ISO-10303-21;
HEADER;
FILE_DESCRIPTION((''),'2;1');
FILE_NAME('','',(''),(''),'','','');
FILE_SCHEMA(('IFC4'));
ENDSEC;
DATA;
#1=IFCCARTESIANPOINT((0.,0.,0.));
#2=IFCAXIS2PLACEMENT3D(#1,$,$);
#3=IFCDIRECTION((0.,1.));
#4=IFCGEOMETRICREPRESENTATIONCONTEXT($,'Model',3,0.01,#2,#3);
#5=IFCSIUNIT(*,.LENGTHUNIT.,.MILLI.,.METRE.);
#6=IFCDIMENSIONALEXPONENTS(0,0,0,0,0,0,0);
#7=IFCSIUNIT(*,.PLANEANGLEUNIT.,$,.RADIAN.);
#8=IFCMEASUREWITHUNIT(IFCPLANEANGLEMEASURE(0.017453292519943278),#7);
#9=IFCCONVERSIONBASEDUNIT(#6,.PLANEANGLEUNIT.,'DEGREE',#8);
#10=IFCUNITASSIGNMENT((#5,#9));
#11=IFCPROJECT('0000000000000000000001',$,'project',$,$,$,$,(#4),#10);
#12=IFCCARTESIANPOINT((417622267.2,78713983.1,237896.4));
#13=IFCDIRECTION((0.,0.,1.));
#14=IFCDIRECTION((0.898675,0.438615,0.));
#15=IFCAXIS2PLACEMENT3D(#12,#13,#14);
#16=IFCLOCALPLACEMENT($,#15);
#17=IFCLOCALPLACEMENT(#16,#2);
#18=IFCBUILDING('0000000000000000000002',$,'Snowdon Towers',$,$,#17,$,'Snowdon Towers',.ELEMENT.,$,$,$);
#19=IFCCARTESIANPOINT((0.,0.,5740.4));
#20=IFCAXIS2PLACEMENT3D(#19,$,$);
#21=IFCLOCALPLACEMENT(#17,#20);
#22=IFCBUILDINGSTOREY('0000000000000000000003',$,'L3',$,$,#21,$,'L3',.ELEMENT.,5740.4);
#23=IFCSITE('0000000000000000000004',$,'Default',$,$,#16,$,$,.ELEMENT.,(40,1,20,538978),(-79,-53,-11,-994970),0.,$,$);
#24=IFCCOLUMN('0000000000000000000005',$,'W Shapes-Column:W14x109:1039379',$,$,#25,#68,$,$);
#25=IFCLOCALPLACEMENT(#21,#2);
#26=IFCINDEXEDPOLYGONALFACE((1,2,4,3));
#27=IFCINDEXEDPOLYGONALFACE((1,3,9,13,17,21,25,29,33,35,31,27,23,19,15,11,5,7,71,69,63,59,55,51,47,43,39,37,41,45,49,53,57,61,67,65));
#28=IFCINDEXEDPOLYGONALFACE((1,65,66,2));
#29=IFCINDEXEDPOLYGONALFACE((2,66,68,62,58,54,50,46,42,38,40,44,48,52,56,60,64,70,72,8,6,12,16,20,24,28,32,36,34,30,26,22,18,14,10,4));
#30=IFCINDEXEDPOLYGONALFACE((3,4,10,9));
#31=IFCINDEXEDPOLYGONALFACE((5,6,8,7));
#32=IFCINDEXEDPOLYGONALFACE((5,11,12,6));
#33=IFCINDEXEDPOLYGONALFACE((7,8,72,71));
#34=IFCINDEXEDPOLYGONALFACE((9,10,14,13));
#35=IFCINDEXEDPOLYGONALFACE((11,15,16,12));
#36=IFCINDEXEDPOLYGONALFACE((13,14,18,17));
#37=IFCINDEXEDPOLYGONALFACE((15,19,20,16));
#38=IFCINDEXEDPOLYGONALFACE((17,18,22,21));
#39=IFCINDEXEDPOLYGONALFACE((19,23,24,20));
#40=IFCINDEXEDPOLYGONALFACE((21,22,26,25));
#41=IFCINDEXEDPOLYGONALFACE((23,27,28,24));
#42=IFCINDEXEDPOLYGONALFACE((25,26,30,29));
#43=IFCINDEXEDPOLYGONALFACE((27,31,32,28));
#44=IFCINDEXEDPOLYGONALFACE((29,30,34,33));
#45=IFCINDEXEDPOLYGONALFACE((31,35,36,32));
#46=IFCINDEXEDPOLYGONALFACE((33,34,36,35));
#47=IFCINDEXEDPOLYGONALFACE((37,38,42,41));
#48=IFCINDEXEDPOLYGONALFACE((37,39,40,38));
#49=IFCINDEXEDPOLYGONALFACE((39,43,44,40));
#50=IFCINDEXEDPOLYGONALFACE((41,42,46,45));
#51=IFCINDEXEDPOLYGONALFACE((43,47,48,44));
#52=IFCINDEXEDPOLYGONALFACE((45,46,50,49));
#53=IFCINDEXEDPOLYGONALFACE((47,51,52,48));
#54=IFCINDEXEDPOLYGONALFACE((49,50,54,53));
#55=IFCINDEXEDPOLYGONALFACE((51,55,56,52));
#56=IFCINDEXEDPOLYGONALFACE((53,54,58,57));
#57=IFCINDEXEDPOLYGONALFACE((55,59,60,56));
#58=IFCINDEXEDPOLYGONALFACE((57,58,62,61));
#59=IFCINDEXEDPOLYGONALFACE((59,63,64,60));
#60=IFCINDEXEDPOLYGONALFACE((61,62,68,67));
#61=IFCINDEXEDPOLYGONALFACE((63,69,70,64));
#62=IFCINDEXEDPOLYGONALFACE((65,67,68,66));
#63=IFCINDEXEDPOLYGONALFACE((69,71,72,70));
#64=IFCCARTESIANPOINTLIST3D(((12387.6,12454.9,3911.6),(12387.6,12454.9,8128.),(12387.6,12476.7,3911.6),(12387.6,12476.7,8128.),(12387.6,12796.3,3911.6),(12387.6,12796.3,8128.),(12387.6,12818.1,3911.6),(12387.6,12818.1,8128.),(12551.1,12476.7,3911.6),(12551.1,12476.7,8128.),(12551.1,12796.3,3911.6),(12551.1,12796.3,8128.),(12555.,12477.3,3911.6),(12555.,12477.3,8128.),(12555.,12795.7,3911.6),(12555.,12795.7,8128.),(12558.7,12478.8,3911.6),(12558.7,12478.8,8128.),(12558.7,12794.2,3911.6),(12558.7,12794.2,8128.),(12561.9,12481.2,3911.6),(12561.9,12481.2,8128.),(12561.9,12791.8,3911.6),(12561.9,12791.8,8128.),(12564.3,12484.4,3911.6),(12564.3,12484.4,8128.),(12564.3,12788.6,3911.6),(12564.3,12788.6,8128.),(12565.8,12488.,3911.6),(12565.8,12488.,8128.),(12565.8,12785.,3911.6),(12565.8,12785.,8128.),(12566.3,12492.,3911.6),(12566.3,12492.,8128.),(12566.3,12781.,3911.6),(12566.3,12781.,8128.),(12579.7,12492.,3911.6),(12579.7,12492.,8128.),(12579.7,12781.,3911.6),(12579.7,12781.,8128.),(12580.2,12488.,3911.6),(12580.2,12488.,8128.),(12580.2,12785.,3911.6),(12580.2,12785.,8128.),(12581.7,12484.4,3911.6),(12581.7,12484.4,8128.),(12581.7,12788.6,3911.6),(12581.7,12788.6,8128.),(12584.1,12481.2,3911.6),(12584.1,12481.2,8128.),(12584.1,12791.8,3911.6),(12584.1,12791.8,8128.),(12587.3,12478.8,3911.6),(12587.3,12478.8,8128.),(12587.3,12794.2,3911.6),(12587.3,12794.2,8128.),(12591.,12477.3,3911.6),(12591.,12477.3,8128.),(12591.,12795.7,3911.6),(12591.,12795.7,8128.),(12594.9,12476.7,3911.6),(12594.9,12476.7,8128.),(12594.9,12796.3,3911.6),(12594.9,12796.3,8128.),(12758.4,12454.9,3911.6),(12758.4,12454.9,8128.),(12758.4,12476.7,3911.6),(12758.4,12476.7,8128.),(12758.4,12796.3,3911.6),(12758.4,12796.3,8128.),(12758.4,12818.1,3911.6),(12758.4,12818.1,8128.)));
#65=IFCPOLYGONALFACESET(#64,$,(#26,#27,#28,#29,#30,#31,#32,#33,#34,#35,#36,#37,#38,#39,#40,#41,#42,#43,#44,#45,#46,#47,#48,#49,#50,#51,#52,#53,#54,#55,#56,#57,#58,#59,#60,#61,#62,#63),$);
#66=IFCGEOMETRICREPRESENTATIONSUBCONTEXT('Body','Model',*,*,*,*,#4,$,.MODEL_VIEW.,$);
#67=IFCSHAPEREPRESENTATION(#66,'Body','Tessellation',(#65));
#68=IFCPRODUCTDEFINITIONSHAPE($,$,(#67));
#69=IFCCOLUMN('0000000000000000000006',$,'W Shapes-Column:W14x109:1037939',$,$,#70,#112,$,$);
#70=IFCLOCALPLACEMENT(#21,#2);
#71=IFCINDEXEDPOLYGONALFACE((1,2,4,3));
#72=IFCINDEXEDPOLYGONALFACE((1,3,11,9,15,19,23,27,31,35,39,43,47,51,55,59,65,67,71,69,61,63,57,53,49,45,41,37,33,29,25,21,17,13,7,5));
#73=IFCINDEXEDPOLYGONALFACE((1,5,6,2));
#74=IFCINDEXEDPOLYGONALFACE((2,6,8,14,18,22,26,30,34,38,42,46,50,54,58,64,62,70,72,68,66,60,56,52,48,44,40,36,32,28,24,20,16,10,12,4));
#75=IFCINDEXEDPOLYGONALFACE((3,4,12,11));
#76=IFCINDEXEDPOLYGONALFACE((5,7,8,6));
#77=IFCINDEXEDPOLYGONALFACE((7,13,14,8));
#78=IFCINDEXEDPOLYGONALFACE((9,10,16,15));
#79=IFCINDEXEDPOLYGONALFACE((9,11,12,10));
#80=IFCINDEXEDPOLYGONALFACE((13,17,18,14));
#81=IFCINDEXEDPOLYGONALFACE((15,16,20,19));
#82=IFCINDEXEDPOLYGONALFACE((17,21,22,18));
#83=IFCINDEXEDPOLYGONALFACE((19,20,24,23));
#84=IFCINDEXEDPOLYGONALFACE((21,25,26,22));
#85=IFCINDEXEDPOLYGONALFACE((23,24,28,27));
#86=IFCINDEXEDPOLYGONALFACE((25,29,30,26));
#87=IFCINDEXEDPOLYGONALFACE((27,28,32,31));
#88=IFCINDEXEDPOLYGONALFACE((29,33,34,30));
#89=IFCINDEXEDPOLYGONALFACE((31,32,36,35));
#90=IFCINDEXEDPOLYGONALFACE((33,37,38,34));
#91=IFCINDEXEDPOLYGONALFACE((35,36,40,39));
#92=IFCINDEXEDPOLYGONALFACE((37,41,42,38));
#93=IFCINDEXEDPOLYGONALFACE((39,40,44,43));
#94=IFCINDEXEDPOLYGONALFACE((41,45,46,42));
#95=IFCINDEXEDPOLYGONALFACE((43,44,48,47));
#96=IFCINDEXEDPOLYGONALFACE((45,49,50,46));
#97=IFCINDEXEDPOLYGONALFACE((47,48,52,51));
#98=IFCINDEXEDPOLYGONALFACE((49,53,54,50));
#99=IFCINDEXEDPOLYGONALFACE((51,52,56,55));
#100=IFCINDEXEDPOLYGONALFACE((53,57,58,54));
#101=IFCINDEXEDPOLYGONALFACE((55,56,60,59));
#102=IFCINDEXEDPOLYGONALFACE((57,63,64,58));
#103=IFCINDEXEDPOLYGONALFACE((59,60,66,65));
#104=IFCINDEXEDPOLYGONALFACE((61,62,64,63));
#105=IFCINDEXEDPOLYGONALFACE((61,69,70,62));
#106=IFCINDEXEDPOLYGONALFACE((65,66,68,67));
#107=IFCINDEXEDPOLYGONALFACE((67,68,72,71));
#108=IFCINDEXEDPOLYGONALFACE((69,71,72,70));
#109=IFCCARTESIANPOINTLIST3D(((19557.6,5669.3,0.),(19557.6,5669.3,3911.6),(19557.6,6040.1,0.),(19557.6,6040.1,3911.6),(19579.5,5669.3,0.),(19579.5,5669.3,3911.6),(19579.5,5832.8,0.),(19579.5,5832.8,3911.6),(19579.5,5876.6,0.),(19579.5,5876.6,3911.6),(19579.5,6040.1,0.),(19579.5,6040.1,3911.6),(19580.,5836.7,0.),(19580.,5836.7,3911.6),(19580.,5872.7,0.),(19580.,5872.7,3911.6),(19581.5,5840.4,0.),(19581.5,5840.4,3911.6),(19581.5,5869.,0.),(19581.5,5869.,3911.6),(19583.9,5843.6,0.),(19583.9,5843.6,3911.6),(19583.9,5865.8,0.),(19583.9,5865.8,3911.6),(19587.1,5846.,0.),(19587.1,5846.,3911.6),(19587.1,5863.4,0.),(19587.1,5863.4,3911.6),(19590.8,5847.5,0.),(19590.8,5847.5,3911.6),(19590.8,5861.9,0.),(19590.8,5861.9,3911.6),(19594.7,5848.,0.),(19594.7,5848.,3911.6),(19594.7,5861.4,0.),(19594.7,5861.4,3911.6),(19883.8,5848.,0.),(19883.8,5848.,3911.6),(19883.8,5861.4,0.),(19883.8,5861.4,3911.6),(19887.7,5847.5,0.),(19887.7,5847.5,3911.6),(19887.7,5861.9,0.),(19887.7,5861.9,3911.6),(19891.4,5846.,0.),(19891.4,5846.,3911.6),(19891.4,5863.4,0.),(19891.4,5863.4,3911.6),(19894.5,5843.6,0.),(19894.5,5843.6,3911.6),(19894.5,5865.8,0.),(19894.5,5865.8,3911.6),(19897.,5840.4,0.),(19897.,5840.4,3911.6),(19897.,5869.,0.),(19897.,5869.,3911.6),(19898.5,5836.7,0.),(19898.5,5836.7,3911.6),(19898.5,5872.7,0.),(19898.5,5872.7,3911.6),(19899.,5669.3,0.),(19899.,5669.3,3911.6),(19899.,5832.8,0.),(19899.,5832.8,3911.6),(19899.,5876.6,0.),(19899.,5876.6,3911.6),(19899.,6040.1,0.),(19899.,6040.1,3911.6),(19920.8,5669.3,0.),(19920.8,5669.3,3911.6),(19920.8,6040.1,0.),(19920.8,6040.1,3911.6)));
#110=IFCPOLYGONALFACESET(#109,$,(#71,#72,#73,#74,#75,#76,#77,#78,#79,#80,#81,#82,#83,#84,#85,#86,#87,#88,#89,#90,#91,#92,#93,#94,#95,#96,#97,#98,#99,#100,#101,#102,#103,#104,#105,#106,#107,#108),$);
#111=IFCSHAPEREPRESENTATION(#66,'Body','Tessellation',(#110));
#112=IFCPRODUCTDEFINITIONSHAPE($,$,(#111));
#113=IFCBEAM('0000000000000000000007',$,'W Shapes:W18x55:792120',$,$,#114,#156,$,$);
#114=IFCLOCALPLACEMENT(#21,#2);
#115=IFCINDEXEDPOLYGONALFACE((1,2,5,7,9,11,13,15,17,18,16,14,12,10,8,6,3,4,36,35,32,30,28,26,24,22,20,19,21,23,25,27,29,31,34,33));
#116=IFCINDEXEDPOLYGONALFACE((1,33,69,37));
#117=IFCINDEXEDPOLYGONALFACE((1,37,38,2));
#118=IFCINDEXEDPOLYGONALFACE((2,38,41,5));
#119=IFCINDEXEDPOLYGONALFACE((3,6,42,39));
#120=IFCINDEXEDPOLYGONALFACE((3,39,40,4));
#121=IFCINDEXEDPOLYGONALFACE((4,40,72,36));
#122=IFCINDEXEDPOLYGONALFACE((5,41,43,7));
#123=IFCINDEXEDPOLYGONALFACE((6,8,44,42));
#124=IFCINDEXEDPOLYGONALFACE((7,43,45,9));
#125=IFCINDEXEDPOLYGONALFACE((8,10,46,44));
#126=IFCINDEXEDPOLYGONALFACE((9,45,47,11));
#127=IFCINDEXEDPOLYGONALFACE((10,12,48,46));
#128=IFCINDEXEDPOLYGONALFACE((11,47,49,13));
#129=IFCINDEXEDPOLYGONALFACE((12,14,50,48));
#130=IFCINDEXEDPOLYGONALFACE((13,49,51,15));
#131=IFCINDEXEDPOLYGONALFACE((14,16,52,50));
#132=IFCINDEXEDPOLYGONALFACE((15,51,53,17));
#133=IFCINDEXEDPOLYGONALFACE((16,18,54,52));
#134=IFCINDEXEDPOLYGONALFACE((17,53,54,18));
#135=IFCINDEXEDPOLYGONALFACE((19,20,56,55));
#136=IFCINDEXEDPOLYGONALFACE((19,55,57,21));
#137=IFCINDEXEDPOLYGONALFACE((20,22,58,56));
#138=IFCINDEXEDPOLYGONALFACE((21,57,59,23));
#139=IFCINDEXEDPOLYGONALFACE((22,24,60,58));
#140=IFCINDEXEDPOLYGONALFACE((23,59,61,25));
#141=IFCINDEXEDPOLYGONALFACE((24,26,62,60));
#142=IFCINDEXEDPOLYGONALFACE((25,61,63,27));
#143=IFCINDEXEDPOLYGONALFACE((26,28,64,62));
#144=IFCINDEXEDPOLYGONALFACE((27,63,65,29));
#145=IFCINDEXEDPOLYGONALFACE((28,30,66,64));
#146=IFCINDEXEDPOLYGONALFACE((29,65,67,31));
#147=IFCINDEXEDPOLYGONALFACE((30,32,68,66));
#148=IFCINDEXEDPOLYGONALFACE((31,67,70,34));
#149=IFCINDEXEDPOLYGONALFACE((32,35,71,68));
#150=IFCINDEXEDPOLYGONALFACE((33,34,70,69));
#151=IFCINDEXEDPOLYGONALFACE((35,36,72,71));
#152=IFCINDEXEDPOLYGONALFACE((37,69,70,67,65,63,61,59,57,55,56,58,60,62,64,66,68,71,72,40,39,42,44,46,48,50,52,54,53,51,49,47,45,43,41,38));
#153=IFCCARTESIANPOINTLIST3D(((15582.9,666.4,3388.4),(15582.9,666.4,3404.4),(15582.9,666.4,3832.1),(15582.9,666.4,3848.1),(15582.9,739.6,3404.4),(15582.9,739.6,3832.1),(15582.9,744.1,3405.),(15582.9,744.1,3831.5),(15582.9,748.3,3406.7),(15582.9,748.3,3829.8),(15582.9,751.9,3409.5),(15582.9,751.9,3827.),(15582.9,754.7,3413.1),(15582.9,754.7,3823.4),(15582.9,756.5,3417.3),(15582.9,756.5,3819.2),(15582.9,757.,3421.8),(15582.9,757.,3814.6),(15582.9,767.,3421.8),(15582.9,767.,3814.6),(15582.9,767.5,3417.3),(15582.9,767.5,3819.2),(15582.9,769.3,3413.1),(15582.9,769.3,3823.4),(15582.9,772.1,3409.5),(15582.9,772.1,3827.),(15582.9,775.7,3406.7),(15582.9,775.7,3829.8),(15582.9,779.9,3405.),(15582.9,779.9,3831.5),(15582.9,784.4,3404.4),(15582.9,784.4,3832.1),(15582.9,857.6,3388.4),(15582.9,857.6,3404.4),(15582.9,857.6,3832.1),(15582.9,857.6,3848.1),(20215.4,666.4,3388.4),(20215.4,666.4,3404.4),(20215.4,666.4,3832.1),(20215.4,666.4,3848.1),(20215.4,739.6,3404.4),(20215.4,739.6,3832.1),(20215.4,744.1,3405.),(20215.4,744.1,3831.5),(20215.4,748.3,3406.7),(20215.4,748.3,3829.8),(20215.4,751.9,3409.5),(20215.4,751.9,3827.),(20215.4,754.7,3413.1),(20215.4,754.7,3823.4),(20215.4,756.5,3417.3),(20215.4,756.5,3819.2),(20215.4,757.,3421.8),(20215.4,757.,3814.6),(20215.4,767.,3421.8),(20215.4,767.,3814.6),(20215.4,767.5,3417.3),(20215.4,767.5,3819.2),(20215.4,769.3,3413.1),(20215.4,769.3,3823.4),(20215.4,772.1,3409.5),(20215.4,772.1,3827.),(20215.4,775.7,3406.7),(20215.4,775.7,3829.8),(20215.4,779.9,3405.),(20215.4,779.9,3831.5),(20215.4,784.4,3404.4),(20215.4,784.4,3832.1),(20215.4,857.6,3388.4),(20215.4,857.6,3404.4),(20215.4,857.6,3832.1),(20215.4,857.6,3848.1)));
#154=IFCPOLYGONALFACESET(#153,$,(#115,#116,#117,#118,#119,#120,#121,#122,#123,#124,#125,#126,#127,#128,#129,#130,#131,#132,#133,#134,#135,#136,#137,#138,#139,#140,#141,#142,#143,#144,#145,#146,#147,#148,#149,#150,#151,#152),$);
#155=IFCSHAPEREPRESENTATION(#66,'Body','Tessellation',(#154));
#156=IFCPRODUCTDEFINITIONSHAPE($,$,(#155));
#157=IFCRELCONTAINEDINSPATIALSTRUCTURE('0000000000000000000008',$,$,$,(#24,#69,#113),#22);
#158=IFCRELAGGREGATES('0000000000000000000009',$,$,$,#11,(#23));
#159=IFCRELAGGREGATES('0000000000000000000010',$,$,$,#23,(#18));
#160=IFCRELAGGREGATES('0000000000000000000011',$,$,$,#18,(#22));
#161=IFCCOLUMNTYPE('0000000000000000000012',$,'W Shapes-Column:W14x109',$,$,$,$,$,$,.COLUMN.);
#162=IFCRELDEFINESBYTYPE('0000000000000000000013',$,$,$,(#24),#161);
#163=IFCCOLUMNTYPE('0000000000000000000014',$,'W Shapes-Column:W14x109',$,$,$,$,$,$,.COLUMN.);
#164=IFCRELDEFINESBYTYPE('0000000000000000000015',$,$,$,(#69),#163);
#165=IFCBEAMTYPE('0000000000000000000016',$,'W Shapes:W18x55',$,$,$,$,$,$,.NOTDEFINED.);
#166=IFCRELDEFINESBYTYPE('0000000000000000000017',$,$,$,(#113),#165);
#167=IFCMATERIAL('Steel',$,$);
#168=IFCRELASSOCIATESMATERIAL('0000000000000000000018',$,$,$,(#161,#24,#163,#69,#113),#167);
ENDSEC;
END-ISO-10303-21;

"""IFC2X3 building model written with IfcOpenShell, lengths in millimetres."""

from ifc_helpers import new_model, entity, si_unit, converted_unit, direction, frame, frame_2d, origin, place, context, subcontext, project, spatial, i_section, extrude, source, transform, mapped, material, type_object, type_shapes, element, save


model = new_model("IFC2X3")

# Units and contexts
model_context = context("Model", 3, precision=0.01, world=origin(), true_north=direction((0.0, 1.0)))
body_context = subcontext(model_context, "Body", "Model", "MODEL_VIEW")
ifc_project = project(units=[si_unit("LENGTHUNIT", "METRE", prefix="MILLI"), converted_unit("PLANEANGLEUNIT", "DEGREE", entity("IfcPlaneAngleMeasure", 0.017453292519943278), si_unit("PLANEANGLEUNIT", "RADIAN"), dimensions=[0, 0, 0, 0, 0, 0, 0])], contexts=[model_context])

# Site, building, storey
site_placement = place(None, frame((417622267.2, 78713983.1, 237896.4), z_axis=(0.0, 0.0, 1.0), x_axis=(0.898675, 0.438615, 0.0)))
site = spatial("IfcSite", under=ifc_project, at=site_placement, Name="Default", CompositionType="ELEMENT", RefLatitude=(40, 1, 20, 538978), RefLongitude=(-79, -53, -11, -994970), RefElevation=0.0)
building_placement = place(site_placement, origin())
building = spatial("IfcBuilding", under=site, at=building_placement, Name="Snowdon Towers", LongName="Snowdon Towers", CompositionType="ELEMENT")
storey_placement = place(building_placement, frame((0.0, 0.0, 5740.4)))
storey = spatial("IfcBuildingStorey", under=building, at=storey_placement, Name="L3", LongName="L3", CompositionType="ELEMENT", Elevation=5740.4)

# Columns
ifc_material_1 = material(Name="Steel")
column_type_1 = type_object("IfcColumnType", Name="W Shapes-Column:W14x109", PredefinedType="COLUMN", material=ifc_material_1)
shared_shape_1 = source(origin(), body_context, "Body", "SweptSolid", [
    extrude(i_section(OverallWidth=370.8, OverallDepth=363.2, WebThickness=13.3, FlangeThickness=21.8, FilletRadius=15.2, at=frame_2d((0.0, 0.0), x_axis=(1.0, 0.0))), frame((0.0, 0.0, 9652.0), z_axis=(0.0, 0.0, 1.0), x_axis=(-1.0, 0.0, 0.0)), (0.0, 0.0, 1.0), 4216.4),
])
type_shapes(column_type_1, [shared_shape_1])
for number, where, z_axis, x_axis, name in (
    (1, (12573.0, 12636.5, -5740.4), (0.0, 0.0, 1.0), (-1.0, 0.0, 0.0), "W Shapes-Column:W14x109:1039379"),
):
    element("IfcColumn", number, at=place(storey_placement, frame(where, z_axis=z_axis, x_axis=x_axis)), inside=storey, type_object=column_type_1, material=ifc_material_1, Name=name, context=body_context, shape_type="MappedRepresentation", body=[
        mapped(shared_shape_1, transform((0.0, 0.0, 0.0), scale=1.0)),
    ])
column_type_2 = type_object("IfcColumnType", Name="W Shapes-Column:W14x109", PredefinedType="COLUMN", material=ifc_material_1)
shared_shape_2 = source(origin(), body_context, "Body", "SweptSolid", [
    extrude(i_section(OverallWidth=370.8, OverallDepth=363.2, WebThickness=13.3, FlangeThickness=21.8, FilletRadius=15.2, at=frame_2d((0.0, 0.0), x_axis=(1.0, 0.0))), frame((0.0, 0.0, 5740.4), z_axis=(0.0, 0.0, 1.0), x_axis=(-1.0, 0.0, 0.0)), (0.0, 0.0, 1.0), 3911.6),
])
type_shapes(column_type_2, [shared_shape_2])
column_placement = place(storey_placement, frame((19739.2, 5854.7, -5740.4), z_axis=(0.0, 0.0, 1.0), x_axis=(0.0, 1.0, 0.0)))
element("IfcColumn", 2, at=column_placement, inside=storey, type_object=column_type_2, material=ifc_material_1, Name="W Shapes-Column:W14x109:1037939", context=body_context, shape_type="MappedRepresentation", body=[
    mapped(shared_shape_2, transform((0.0, 0.0, 0.0), scale=1.0)),
])

# Beam
beam_type_1 = type_object("IfcBeamType", Name="W Shapes:W18x55", PredefinedType="NOTDEFINED")
beam_1_placement = place(storey_placement, frame((15582.9, 762.0, 3911.6)))
element("IfcBeam", 3, at=beam_1_placement, inside=storey, type_object=beam_type_1, material=ifc_material_1, Name="W Shapes:W18x55:792120", context=body_context, shape_type="SweptSolid", body=[
    extrude(i_section(OverallWidth=191.3, OverallDepth=459.7, WebThickness=9.9, FlangeThickness=16.0, FilletRadius=17.5, at=frame_2d((0.0, 0.0), x_axis=(0.0, 1.0))), frame((0.0, 0.0, -293.4), z_axis=(1.0, 0.0, 0.0), x_axis=(0.0, 0.0, -1.0)), (0.0, 0.0, 1.0), 4632.5),
])

save(model, "model.ifc")
